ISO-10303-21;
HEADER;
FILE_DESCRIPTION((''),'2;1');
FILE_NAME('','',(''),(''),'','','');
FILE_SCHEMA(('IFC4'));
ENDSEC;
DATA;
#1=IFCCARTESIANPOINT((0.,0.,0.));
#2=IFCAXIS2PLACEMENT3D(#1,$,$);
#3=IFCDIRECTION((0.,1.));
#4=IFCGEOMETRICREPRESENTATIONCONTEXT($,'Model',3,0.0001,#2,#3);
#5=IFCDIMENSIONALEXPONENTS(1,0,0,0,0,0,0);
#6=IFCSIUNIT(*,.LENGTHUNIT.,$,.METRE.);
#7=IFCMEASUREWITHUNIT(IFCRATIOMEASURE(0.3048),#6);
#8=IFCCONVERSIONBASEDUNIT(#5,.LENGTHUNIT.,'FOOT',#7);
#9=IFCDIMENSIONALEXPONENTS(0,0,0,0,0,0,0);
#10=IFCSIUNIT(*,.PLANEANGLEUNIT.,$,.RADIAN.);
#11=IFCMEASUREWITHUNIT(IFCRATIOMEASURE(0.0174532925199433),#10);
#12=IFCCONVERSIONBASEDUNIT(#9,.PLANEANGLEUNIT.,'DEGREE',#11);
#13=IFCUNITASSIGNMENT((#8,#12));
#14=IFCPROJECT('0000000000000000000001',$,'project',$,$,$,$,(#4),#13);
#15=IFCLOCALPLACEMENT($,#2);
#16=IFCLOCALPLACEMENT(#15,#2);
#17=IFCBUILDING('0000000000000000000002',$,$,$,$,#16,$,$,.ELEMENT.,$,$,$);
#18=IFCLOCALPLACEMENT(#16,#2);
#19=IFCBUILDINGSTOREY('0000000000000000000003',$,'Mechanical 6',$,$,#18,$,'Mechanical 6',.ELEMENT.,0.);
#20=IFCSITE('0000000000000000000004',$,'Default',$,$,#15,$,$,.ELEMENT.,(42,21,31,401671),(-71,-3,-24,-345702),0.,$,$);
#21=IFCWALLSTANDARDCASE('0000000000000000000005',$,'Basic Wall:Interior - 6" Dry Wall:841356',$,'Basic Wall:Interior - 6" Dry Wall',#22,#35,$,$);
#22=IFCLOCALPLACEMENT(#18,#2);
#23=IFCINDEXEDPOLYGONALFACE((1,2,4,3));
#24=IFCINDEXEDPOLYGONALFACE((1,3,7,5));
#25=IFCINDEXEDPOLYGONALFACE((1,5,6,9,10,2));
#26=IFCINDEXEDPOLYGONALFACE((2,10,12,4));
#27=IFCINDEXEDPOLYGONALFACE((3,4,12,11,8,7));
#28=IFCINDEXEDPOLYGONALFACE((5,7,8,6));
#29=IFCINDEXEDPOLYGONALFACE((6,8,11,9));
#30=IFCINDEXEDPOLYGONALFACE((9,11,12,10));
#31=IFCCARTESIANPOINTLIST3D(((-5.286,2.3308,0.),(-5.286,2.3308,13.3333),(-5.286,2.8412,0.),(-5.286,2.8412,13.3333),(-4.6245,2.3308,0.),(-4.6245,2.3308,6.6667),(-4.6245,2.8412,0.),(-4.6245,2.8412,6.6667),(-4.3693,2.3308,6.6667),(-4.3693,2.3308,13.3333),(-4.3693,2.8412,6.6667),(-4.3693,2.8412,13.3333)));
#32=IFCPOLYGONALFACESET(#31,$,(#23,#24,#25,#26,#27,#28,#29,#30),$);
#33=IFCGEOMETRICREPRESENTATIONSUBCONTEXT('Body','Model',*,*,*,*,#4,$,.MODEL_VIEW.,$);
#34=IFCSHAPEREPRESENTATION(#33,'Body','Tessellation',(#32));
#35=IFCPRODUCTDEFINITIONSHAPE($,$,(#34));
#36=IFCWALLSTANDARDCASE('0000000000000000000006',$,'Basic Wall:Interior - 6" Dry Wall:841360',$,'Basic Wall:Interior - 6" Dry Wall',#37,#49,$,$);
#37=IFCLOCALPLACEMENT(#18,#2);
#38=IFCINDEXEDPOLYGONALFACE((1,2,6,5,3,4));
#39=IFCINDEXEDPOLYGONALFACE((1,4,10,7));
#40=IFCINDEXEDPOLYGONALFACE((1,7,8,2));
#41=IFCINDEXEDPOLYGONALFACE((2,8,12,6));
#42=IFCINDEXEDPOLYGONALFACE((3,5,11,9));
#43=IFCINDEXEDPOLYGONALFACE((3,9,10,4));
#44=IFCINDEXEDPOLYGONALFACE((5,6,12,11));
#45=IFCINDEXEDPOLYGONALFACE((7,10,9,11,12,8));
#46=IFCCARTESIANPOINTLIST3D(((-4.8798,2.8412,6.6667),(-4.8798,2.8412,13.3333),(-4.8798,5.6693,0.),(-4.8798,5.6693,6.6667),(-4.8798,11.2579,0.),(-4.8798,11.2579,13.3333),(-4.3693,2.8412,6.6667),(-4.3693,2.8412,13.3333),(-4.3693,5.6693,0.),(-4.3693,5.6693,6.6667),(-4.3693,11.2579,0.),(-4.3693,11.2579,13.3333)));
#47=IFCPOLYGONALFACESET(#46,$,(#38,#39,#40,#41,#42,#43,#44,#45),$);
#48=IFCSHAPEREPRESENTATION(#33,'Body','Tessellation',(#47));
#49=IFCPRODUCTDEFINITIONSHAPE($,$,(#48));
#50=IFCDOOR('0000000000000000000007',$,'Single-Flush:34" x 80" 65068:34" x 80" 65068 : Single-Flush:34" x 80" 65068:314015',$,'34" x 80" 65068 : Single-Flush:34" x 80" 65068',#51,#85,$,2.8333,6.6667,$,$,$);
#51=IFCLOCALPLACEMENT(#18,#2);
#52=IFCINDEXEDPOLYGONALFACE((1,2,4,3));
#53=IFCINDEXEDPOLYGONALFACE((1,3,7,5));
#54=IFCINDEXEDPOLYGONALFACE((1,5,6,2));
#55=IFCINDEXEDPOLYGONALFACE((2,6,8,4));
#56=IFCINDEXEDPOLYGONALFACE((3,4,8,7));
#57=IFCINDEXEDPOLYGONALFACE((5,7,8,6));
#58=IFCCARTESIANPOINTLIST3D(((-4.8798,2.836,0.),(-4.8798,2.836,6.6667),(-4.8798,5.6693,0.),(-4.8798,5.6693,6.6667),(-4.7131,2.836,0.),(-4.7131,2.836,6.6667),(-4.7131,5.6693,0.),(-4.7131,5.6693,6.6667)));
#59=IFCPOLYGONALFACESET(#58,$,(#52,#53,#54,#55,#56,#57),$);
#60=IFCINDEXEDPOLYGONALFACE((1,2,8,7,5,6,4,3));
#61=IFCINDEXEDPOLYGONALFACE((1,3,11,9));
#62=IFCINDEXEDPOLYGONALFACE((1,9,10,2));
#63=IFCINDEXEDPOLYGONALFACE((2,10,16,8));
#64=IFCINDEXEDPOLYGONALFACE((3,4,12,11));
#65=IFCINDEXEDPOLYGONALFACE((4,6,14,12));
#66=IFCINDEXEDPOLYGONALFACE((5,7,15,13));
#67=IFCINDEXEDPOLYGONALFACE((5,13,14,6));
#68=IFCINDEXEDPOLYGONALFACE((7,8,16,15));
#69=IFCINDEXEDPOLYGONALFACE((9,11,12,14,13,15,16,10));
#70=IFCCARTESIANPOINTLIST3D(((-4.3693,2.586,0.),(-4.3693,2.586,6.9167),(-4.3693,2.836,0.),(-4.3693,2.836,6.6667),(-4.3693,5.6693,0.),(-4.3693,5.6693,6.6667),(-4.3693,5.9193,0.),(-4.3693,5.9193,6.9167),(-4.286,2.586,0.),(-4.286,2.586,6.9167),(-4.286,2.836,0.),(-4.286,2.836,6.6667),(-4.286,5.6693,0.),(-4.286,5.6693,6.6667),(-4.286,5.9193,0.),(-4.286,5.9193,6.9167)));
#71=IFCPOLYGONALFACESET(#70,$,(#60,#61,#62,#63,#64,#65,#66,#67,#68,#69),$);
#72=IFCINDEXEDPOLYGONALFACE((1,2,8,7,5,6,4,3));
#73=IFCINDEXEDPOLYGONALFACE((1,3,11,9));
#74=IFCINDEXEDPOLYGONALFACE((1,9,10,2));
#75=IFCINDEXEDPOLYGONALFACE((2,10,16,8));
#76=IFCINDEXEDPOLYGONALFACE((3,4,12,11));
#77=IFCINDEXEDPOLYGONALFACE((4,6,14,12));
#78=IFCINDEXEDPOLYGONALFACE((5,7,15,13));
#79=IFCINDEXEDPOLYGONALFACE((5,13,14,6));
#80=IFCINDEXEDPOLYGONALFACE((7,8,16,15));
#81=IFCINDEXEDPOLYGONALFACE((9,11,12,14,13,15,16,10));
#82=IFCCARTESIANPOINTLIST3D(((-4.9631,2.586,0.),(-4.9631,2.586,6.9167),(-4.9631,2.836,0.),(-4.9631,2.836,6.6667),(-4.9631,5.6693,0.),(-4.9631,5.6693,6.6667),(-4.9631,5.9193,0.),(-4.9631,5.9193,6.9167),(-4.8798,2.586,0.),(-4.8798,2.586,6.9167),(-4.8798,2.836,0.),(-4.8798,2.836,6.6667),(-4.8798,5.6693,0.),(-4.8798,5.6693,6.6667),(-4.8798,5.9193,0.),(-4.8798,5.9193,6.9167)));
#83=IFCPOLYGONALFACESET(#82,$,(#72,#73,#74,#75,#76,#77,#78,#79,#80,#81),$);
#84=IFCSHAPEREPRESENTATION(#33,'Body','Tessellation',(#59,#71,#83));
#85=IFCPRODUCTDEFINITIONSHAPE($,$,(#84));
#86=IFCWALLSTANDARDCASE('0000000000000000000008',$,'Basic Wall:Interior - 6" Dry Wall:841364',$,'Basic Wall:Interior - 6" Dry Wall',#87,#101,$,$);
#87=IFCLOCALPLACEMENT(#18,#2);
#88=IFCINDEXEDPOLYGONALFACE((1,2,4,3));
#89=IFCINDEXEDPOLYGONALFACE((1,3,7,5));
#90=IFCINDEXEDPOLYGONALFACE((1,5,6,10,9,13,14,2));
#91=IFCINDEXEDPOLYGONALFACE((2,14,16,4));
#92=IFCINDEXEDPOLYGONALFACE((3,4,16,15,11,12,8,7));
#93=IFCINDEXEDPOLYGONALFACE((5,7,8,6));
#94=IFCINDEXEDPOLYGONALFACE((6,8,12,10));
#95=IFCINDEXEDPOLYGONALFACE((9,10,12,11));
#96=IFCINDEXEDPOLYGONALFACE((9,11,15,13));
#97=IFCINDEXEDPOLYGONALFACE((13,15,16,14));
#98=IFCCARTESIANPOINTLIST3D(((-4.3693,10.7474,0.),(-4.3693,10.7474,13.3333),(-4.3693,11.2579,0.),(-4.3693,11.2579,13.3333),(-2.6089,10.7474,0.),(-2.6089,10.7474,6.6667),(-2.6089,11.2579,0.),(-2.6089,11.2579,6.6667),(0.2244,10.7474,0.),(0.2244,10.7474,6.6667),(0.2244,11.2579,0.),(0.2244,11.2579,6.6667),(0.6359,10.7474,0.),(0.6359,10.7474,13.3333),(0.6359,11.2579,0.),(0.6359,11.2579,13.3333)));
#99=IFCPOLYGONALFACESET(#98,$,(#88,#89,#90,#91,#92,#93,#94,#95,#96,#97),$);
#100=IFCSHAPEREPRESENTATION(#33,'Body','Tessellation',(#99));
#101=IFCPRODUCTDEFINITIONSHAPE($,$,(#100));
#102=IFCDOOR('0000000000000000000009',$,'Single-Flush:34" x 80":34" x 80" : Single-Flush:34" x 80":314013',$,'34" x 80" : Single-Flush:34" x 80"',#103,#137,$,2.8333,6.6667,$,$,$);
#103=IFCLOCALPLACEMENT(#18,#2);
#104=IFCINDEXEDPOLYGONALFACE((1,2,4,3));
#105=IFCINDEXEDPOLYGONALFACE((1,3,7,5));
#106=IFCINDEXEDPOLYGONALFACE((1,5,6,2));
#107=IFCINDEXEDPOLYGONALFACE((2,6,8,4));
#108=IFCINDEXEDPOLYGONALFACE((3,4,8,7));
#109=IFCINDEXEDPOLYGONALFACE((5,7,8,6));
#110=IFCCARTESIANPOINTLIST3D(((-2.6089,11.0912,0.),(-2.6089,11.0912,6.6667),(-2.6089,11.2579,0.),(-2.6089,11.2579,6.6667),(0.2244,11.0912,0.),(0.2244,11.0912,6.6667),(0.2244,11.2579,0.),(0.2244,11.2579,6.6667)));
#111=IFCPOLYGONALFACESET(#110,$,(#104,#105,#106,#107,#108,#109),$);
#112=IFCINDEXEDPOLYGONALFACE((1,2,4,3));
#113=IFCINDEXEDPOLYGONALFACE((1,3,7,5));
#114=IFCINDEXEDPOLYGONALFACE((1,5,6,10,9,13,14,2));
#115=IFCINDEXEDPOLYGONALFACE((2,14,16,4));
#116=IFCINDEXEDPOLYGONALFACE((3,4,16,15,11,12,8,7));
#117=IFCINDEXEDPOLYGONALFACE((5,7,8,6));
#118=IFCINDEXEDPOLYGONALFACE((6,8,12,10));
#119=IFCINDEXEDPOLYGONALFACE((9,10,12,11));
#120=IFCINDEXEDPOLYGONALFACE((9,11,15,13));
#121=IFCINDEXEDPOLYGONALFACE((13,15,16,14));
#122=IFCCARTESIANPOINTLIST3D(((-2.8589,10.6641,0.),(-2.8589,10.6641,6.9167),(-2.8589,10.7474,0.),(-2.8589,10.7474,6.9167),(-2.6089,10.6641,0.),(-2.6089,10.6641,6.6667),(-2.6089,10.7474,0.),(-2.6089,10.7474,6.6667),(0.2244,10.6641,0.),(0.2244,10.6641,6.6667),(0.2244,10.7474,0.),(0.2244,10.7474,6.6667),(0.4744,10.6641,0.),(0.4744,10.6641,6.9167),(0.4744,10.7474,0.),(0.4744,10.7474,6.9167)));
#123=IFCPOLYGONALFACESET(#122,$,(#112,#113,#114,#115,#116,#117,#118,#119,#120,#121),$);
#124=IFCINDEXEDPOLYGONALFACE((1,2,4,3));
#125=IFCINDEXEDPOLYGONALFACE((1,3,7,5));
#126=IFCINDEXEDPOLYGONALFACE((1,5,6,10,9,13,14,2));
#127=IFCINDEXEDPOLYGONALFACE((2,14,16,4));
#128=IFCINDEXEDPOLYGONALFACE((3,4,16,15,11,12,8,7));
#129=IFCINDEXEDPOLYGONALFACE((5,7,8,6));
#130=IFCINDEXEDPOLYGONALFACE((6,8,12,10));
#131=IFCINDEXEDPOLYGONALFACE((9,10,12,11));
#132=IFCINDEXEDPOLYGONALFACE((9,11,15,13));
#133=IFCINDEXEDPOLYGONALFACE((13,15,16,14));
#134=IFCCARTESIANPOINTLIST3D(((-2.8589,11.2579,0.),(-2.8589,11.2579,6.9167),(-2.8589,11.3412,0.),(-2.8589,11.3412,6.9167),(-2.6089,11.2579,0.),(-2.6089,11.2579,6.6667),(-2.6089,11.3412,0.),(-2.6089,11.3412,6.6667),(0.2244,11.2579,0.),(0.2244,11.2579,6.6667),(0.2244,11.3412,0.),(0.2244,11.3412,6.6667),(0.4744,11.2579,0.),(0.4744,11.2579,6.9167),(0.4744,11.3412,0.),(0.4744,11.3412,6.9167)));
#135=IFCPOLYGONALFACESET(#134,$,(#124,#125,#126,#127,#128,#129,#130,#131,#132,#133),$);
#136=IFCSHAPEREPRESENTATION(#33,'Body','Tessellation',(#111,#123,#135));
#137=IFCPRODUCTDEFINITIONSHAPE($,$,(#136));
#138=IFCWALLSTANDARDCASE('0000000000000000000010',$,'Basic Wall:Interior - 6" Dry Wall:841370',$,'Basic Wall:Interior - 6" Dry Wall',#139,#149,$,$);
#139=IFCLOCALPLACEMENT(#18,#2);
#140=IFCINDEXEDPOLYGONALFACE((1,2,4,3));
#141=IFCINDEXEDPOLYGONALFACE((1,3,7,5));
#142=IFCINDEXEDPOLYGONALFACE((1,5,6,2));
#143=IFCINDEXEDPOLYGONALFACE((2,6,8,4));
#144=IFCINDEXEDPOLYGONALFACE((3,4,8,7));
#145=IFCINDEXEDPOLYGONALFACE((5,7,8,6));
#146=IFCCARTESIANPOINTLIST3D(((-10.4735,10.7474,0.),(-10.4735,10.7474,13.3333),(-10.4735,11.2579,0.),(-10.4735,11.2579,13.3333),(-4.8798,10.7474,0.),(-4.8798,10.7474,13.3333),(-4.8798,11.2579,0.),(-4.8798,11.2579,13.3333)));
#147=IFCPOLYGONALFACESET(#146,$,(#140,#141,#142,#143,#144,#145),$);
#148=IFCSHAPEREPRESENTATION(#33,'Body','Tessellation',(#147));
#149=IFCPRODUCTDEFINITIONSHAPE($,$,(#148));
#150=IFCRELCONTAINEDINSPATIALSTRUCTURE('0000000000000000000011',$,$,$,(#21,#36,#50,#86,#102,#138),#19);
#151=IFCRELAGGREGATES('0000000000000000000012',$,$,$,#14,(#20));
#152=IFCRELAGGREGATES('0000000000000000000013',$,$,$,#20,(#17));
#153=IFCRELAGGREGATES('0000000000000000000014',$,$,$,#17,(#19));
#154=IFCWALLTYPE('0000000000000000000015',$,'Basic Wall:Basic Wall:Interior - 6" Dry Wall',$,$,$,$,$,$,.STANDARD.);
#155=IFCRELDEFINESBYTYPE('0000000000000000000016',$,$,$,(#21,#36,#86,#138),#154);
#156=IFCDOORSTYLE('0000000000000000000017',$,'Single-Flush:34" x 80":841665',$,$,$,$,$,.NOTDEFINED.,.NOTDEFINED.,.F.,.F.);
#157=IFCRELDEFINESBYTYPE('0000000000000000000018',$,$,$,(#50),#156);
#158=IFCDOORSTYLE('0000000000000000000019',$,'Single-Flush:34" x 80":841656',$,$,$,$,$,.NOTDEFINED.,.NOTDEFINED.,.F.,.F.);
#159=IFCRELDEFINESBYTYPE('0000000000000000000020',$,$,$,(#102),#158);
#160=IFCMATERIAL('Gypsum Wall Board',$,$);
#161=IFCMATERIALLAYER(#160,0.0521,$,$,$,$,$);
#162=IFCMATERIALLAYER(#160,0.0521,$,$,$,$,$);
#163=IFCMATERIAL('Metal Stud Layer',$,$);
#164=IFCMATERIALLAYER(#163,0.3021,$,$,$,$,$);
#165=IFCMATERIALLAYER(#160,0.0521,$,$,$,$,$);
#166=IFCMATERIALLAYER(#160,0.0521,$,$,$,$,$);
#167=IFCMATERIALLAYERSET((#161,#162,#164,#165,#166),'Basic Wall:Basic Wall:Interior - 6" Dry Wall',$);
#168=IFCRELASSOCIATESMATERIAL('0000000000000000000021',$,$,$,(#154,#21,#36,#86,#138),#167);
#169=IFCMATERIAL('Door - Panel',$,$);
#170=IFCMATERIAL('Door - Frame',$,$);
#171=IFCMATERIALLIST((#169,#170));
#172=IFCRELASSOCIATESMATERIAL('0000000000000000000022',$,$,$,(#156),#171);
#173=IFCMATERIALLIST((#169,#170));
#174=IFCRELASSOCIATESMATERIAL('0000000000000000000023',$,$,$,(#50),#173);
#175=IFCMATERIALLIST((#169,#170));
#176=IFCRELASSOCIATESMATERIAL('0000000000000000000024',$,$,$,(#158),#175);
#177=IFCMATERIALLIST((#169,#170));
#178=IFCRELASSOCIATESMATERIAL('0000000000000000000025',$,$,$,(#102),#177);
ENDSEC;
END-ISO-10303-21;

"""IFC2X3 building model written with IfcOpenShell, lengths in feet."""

from ifc_helpers import new_model, entity, si_unit, converted_unit, direction, frame, frame_2d, origin, origin_2d_with_axis, place, context, subcontext, project, spatial, polyline, rectangle, outline, extrude, source, transform, mapped, material, material_list, layer, layer_set, layer_usage, type_object, type_shapes, element, fill, save


model = new_model("IFC2X3")

# Units and contexts
model_context = context("Model", 3, precision=0.0001, world=origin(), true_north=direction((0.0, 1.0)))
body_context = subcontext(model_context, "Body", "Model", "MODEL_VIEW")
ifc_project = project(units=[converted_unit("LENGTHUNIT", "FOOT", entity("IfcRatioMeasure", 0.3048), si_unit("LENGTHUNIT", "METRE"), dimensions=[1, 0, 0, 0, 0, 0, 0]), converted_unit("PLANEANGLEUNIT", "DEGREE", entity("IfcRatioMeasure", 0.0174532925199433), si_unit("PLANEANGLEUNIT", "RADIAN"), dimensions=[0, 0, 0, 0, 0, 0, 0])], contexts=[model_context])

# Site, building, storey
site_placement = place(None, origin())
site = spatial("IfcSite", under=ifc_project, at=site_placement, Name="Default", CompositionType="ELEMENT", RefLatitude=(42, 21, 31, 401671), RefLongitude=(-71, -3, -24, -345702), RefElevation=0.0)
building_placement = place(site_placement, origin())
building = spatial("IfcBuilding", under=site, at=building_placement, CompositionType="ELEMENT")
storey_placement = place(building_placement, origin())
storey = spatial("IfcBuildingStorey", under=building, at=storey_placement, Name="Mechanical 6", LongName="Mechanical 6", CompositionType="ELEMENT", Elevation=0.0)

# Wall, opening
ifc_material_1 = material(Name="Gypsum Wall Board")
ifc_layer_1 = layer(ifc_material_1, 0.0521)
ifc_layer_2 = layer(ifc_material_1, 0.0521)
ifc_material_2 = material(Name="Metal Stud Layer")
ifc_layer_3 = layer(ifc_material_2, 0.3021)
ifc_layer_4 = layer(ifc_material_1, 0.0521)
ifc_layer_5 = layer(ifc_material_1, 0.0521)
ifc_layer_set = layer_set([ifc_layer_1, ifc_layer_2, ifc_layer_3, ifc_layer_4, ifc_layer_5], Name="Basic Wall:Basic Wall:Interior - 6\" Dry Wall")
ifc_layer_usage_1 = layer_usage(ifc_layer_set, "AXIS2", "NEGATIVE", 0.2552)
wall_type = type_object("IfcWallType", Name="Basic Wall:Basic Wall:Interior - 6\" Dry Wall", PredefinedType="STANDARD", material=ifc_layer_set)
wall_1_placement = place(storey_placement, frame((-5.286, 2.586, 0.0)))
wall_1 = element("IfcWallStandardCase", 1, at=wall_1_placement, inside=storey, type_object=wall_type, material=ifc_layer_usage_1, Name="Basic Wall:Interior - 6\" Dry Wall:841356", ObjectType="Basic Wall:Interior - 6\" Dry Wall", context=body_context, shape_type="SweptSolid", body=[
    extrude(rectangle(XDim=0.9167, YDim=0.5104, at=frame_2d((0.4583, 0.0), x_axis=(-1.0, 0.0))), origin(), (0.0, 0.0, 1.0), 13.3333),
])
opening_1_placement = place(wall_1_placement, origin())
element("IfcOpeningElement", 2, at=opening_1_placement, cuts=wall_1, ObjectType="Opening", context=body_context, shape_type="SweptSolid", body=[
    extrude(rectangle(XDim=6.6667, YDim=0.2552, at=frame_2d((0.0, 0.0), x_axis=(1.0, 0.0))), frame((0.7891, -0.2552, 3.3333), z_axis=(0.0, 1.0, 0.0), x_axis=(0.0, 0.0, -1.0)), (0.0, 0.0, 1.0), 0.5104),
])

# Walls, openings, doors
ifc_layer_usage_2 = layer_usage(ifc_layer_set, "AXIS2", "NEGATIVE", 0.2552)
wall_2_placement = place(storey_placement, frame((-4.6245, 2.8412, 0.0), z_axis=(0.0, 0.0, 1.0), x_axis=(0.0, 1.0, 0.0)))
wall_2 = element("IfcWallStandardCase", 3, at=wall_2_placement, inside=storey, type_object=wall_type, material=ifc_layer_usage_2, Name="Basic Wall:Interior - 6\" Dry Wall:841360", ObjectType="Basic Wall:Interior - 6\" Dry Wall", context=body_context, shape_type="SweptSolid", body=[
    extrude(rectangle(XDim=8.4167, YDim=0.5104, at=frame_2d((4.2083, 0.0), x_axis=(-1.0, 0.0))), origin(), (0.0, 0.0, 1.0), 13.3333),
])
opening_2_placement = place(wall_2_placement, frame((-2.8412, -4.6245, 0.0), z_axis=(0.0, 0.0, 1.0), x_axis=(0.0, -1.0, 0.0)))
opening_2 = element("IfcOpeningElement", 4, at=opening_2_placement, cuts=wall_2, ObjectType="Opening", context=body_context, shape_type="SweptSolid", body=[
    extrude(rectangle(XDim=6.6667, YDim=2.8333, at=origin_2d_with_axis()), frame((-4.3642, 4.2526, 3.3333), z_axis=(-1.0, 0.0, 0.0), x_axis=(0.0, 0.0, 1.0)), (0.0, 0.0, 1.0), 0.5206),
])
ifc_material_3 = material(Name="Door - Panel")
ifc_material_4 = material(Name="Door - Frame")
ifc_material_list_1 = material_list([ifc_material_3, ifc_material_4])
ifc_material_list_2 = material_list([ifc_material_3, ifc_material_4])
door_style_1 = type_object("IfcDoorStyle", Name="Single-Flush:34\" x 80\":841665", ConstructionType="NOTDEFINED", OperationType="NOTDEFINED", ParameterTakesPrecedence=False, Sizeable=False, material=ifc_material_list_2)
shared_shape_1 = source(origin(), body_context, "Body", "SweptSolid", [
    extrude(rectangle(XDim=0.1667, YDim=2.8333, at=frame_2d((0.0, 0.0), x_axis=(1.0, 0.0))), frame((1.4167, -0.0884, 0.0), z_axis=(0.0, 0.0, 1.0), x_axis=(0.0, 1.0, 0.0)), (0.0, 0.0, 1.0), 6.6667),
    extrude(outline(polyline([(-3.3958, -1.6667), (3.5208, -1.6667), (3.5208, 1.6667), (-3.3958, 1.6667), (-3.3958, 1.4167), (3.2708, 1.4167), (3.2708, -1.4167), (-3.3958, -1.4167), (-3.3958, -1.6667)])), frame((1.4167, -0.5989, 3.3958), z_axis=(0.0, 1.0, 0.0), x_axis=(0.0, 0.0, 1.0)), (0.0, 0.0, 1.0), 0.0833),
    extrude(outline(polyline([(-1.6667, -3.5208), (1.6667, -3.5208), (1.6667, 3.3958), (1.4167, 3.3958), (1.4167, -3.2708), (-1.4167, -3.2708), (-1.4167, 3.3958), (-1.6667, 3.3958), (-1.6667, -3.5208)])), frame((1.4167, -0.0051, 3.3958), z_axis=(0.0, 1.0, 0.0), x_axis=(1.0, 0.0, 0.0)), (0.0, 0.0, 1.0), 0.0833),
])
type_shapes(door_style_1, [shared_shape_1])
door_1_placement = place(opening_2_placement, frame((-4.8849, 2.836, 0.0), z_axis=(0.0, 0.0, 1.0), x_axis=(0.0, 1.0, 0.0)))
door_1 = element("IfcDoor", 5, at=door_1_placement, inside=storey, type_object=door_style_1, material=ifc_material_list_1, Name="Single-Flush:34\" x 80\" 65068:34\" x 80\" 65068 : Single-Flush:34\" x 80\" 65068:314015", ObjectType="34\" x 80\" 65068 : Single-Flush:34\" x 80\" 65068", OverallHeight=2.8333, OverallWidth=6.6667, context=body_context, shape_type="MappedRepresentation", body=[
    mapped(shared_shape_1, transform((0.0, 0.0, 0.0), scale=1.0)),
])
fill(opening_2, door_1)
ifc_layer_usage_3 = layer_usage(ifc_layer_set, "AXIS2", "NEGATIVE", 0.2552)
wall_3_placement = place(storey_placement, frame((-4.3693, 11.0026, 0.0)))
wall_3 = element("IfcWallStandardCase", 6, at=wall_3_placement, inside=storey, type_object=wall_type, material=ifc_layer_usage_3, Name="Basic Wall:Interior - 6\" Dry Wall:841364", ObjectType="Basic Wall:Interior - 6\" Dry Wall", context=body_context, shape_type="SweptSolid", body=[
    extrude(rectangle(XDim=5.0052, YDim=0.5104, at=frame_2d((2.5026, 0.0), x_axis=(-1.0, 0.0))), origin(), (0.0, 0.0, 1.0), 13.3333),
])
opening_3_placement = place(wall_3_placement, frame((4.3693, -11.0026, 0.0)))
opening_3 = element("IfcOpeningElement", 7, at=opening_3_placement, cuts=wall_3, ObjectType="Opening", context=body_context, shape_type="SweptSolid", body=[
    extrude(rectangle(XDim=6.6667, YDim=2.8333, at=origin_2d_with_axis()), frame((-1.1923, 10.7423, 3.3333), z_axis=(0.0, 1.0, 0.0), x_axis=(0.0, 0.0, -1.0)), (0.0, 0.0, 1.0), 0.5206),
])
ifc_material_list_3 = material_list([ifc_material_3, ifc_material_4])
ifc_material_list_4 = material_list([ifc_material_3, ifc_material_4])
door_style_2 = type_object("IfcDoorStyle", Name="Single-Flush:34\" x 80\":841656", ConstructionType="NOTDEFINED", OperationType="NOTDEFINED", ParameterTakesPrecedence=False, Sizeable=False, material=ifc_material_list_4)
shared_shape_2 = source(origin(), body_context, "Body", "SweptSolid", [
    extrude(rectangle(XDim=2.8333, YDim=0.1667, at=origin_2d_with_axis()), frame((1.4167, -0.0884, 0.0), z_axis=(0.0, 0.0, 1.0), x_axis=(-1.0, 0.0, 0.0)), (0.0, 0.0, 1.0), 6.6667),
    extrude(outline(polyline([(-1.6667, -3.3958), (-1.4167, -3.3958), (-1.4167, 3.2708), (1.4167, 3.2708), (1.4167, -3.3958), (1.6667, -3.3958), (1.6667, 3.5208), (-1.6667, 3.5208), (-1.6667, -3.3958)])), frame((1.4167, -0.5989, 3.3958), z_axis=(0.0, 1.0, 0.0), x_axis=(-1.0, 0.0, 0.0)), (0.0, 0.0, 1.0), 0.0833),
    extrude(outline(polyline([(-3.5208, -1.6667), (3.3958, -1.6667), (3.3958, -1.4167), (-3.2708, -1.4167), (-3.2708, 1.4167), (3.3958, 1.4167), (3.3958, 1.6667), (-3.5208, 1.6667), (-3.5208, -1.6667)])), frame((1.4167, -0.0051, 3.3958), z_axis=(0.0, 1.0, 0.0), x_axis=(0.0, 0.0, -1.0)), (0.0, 0.0, 1.0), 0.0833),
])
type_shapes(door_style_2, [shared_shape_2])
door_2_placement = place(opening_3_placement, frame((-2.6089, 11.263, 0.0)))
door_2 = element("IfcDoor", 8, at=door_2_placement, inside=storey, type_object=door_style_2, material=ifc_material_list_3, Name="Single-Flush:34\" x 80\":34\" x 80\" : Single-Flush:34\" x 80\":314013", ObjectType="34\" x 80\" : Single-Flush:34\" x 80\"", OverallHeight=2.8333, OverallWidth=6.6667, context=body_context, shape_type="MappedRepresentation", body=[
    mapped(shared_shape_2, transform((0.0, 0.0, 0.0), scale=1.0)),
])
fill(opening_3, door_2)

# Wall
ifc_layer_usage_4 = layer_usage(ifc_layer_set, "AXIS2", "NEGATIVE", 0.2552)
wall_4_placement = place(storey_placement, frame((-4.8798, 11.0026, 0.0), z_axis=(0.0, 0.0, 1.0), x_axis=(-1.0, 0.0, 0.0)))
element("IfcWallStandardCase", 9, at=wall_4_placement, inside=storey, type_object=wall_type, material=ifc_layer_usage_4, Name="Basic Wall:Interior - 6\" Dry Wall:841370", ObjectType="Basic Wall:Interior - 6\" Dry Wall", context=body_context, shape_type="SweptSolid", body=[
    extrude(rectangle(XDim=5.5937, YDim=0.5104, at=frame_2d((2.7969, 0.0), x_axis=(-1.0, 0.0))), origin(), (0.0, 0.0, 1.0), 13.3333),
])

save(model, "model.ifc")
